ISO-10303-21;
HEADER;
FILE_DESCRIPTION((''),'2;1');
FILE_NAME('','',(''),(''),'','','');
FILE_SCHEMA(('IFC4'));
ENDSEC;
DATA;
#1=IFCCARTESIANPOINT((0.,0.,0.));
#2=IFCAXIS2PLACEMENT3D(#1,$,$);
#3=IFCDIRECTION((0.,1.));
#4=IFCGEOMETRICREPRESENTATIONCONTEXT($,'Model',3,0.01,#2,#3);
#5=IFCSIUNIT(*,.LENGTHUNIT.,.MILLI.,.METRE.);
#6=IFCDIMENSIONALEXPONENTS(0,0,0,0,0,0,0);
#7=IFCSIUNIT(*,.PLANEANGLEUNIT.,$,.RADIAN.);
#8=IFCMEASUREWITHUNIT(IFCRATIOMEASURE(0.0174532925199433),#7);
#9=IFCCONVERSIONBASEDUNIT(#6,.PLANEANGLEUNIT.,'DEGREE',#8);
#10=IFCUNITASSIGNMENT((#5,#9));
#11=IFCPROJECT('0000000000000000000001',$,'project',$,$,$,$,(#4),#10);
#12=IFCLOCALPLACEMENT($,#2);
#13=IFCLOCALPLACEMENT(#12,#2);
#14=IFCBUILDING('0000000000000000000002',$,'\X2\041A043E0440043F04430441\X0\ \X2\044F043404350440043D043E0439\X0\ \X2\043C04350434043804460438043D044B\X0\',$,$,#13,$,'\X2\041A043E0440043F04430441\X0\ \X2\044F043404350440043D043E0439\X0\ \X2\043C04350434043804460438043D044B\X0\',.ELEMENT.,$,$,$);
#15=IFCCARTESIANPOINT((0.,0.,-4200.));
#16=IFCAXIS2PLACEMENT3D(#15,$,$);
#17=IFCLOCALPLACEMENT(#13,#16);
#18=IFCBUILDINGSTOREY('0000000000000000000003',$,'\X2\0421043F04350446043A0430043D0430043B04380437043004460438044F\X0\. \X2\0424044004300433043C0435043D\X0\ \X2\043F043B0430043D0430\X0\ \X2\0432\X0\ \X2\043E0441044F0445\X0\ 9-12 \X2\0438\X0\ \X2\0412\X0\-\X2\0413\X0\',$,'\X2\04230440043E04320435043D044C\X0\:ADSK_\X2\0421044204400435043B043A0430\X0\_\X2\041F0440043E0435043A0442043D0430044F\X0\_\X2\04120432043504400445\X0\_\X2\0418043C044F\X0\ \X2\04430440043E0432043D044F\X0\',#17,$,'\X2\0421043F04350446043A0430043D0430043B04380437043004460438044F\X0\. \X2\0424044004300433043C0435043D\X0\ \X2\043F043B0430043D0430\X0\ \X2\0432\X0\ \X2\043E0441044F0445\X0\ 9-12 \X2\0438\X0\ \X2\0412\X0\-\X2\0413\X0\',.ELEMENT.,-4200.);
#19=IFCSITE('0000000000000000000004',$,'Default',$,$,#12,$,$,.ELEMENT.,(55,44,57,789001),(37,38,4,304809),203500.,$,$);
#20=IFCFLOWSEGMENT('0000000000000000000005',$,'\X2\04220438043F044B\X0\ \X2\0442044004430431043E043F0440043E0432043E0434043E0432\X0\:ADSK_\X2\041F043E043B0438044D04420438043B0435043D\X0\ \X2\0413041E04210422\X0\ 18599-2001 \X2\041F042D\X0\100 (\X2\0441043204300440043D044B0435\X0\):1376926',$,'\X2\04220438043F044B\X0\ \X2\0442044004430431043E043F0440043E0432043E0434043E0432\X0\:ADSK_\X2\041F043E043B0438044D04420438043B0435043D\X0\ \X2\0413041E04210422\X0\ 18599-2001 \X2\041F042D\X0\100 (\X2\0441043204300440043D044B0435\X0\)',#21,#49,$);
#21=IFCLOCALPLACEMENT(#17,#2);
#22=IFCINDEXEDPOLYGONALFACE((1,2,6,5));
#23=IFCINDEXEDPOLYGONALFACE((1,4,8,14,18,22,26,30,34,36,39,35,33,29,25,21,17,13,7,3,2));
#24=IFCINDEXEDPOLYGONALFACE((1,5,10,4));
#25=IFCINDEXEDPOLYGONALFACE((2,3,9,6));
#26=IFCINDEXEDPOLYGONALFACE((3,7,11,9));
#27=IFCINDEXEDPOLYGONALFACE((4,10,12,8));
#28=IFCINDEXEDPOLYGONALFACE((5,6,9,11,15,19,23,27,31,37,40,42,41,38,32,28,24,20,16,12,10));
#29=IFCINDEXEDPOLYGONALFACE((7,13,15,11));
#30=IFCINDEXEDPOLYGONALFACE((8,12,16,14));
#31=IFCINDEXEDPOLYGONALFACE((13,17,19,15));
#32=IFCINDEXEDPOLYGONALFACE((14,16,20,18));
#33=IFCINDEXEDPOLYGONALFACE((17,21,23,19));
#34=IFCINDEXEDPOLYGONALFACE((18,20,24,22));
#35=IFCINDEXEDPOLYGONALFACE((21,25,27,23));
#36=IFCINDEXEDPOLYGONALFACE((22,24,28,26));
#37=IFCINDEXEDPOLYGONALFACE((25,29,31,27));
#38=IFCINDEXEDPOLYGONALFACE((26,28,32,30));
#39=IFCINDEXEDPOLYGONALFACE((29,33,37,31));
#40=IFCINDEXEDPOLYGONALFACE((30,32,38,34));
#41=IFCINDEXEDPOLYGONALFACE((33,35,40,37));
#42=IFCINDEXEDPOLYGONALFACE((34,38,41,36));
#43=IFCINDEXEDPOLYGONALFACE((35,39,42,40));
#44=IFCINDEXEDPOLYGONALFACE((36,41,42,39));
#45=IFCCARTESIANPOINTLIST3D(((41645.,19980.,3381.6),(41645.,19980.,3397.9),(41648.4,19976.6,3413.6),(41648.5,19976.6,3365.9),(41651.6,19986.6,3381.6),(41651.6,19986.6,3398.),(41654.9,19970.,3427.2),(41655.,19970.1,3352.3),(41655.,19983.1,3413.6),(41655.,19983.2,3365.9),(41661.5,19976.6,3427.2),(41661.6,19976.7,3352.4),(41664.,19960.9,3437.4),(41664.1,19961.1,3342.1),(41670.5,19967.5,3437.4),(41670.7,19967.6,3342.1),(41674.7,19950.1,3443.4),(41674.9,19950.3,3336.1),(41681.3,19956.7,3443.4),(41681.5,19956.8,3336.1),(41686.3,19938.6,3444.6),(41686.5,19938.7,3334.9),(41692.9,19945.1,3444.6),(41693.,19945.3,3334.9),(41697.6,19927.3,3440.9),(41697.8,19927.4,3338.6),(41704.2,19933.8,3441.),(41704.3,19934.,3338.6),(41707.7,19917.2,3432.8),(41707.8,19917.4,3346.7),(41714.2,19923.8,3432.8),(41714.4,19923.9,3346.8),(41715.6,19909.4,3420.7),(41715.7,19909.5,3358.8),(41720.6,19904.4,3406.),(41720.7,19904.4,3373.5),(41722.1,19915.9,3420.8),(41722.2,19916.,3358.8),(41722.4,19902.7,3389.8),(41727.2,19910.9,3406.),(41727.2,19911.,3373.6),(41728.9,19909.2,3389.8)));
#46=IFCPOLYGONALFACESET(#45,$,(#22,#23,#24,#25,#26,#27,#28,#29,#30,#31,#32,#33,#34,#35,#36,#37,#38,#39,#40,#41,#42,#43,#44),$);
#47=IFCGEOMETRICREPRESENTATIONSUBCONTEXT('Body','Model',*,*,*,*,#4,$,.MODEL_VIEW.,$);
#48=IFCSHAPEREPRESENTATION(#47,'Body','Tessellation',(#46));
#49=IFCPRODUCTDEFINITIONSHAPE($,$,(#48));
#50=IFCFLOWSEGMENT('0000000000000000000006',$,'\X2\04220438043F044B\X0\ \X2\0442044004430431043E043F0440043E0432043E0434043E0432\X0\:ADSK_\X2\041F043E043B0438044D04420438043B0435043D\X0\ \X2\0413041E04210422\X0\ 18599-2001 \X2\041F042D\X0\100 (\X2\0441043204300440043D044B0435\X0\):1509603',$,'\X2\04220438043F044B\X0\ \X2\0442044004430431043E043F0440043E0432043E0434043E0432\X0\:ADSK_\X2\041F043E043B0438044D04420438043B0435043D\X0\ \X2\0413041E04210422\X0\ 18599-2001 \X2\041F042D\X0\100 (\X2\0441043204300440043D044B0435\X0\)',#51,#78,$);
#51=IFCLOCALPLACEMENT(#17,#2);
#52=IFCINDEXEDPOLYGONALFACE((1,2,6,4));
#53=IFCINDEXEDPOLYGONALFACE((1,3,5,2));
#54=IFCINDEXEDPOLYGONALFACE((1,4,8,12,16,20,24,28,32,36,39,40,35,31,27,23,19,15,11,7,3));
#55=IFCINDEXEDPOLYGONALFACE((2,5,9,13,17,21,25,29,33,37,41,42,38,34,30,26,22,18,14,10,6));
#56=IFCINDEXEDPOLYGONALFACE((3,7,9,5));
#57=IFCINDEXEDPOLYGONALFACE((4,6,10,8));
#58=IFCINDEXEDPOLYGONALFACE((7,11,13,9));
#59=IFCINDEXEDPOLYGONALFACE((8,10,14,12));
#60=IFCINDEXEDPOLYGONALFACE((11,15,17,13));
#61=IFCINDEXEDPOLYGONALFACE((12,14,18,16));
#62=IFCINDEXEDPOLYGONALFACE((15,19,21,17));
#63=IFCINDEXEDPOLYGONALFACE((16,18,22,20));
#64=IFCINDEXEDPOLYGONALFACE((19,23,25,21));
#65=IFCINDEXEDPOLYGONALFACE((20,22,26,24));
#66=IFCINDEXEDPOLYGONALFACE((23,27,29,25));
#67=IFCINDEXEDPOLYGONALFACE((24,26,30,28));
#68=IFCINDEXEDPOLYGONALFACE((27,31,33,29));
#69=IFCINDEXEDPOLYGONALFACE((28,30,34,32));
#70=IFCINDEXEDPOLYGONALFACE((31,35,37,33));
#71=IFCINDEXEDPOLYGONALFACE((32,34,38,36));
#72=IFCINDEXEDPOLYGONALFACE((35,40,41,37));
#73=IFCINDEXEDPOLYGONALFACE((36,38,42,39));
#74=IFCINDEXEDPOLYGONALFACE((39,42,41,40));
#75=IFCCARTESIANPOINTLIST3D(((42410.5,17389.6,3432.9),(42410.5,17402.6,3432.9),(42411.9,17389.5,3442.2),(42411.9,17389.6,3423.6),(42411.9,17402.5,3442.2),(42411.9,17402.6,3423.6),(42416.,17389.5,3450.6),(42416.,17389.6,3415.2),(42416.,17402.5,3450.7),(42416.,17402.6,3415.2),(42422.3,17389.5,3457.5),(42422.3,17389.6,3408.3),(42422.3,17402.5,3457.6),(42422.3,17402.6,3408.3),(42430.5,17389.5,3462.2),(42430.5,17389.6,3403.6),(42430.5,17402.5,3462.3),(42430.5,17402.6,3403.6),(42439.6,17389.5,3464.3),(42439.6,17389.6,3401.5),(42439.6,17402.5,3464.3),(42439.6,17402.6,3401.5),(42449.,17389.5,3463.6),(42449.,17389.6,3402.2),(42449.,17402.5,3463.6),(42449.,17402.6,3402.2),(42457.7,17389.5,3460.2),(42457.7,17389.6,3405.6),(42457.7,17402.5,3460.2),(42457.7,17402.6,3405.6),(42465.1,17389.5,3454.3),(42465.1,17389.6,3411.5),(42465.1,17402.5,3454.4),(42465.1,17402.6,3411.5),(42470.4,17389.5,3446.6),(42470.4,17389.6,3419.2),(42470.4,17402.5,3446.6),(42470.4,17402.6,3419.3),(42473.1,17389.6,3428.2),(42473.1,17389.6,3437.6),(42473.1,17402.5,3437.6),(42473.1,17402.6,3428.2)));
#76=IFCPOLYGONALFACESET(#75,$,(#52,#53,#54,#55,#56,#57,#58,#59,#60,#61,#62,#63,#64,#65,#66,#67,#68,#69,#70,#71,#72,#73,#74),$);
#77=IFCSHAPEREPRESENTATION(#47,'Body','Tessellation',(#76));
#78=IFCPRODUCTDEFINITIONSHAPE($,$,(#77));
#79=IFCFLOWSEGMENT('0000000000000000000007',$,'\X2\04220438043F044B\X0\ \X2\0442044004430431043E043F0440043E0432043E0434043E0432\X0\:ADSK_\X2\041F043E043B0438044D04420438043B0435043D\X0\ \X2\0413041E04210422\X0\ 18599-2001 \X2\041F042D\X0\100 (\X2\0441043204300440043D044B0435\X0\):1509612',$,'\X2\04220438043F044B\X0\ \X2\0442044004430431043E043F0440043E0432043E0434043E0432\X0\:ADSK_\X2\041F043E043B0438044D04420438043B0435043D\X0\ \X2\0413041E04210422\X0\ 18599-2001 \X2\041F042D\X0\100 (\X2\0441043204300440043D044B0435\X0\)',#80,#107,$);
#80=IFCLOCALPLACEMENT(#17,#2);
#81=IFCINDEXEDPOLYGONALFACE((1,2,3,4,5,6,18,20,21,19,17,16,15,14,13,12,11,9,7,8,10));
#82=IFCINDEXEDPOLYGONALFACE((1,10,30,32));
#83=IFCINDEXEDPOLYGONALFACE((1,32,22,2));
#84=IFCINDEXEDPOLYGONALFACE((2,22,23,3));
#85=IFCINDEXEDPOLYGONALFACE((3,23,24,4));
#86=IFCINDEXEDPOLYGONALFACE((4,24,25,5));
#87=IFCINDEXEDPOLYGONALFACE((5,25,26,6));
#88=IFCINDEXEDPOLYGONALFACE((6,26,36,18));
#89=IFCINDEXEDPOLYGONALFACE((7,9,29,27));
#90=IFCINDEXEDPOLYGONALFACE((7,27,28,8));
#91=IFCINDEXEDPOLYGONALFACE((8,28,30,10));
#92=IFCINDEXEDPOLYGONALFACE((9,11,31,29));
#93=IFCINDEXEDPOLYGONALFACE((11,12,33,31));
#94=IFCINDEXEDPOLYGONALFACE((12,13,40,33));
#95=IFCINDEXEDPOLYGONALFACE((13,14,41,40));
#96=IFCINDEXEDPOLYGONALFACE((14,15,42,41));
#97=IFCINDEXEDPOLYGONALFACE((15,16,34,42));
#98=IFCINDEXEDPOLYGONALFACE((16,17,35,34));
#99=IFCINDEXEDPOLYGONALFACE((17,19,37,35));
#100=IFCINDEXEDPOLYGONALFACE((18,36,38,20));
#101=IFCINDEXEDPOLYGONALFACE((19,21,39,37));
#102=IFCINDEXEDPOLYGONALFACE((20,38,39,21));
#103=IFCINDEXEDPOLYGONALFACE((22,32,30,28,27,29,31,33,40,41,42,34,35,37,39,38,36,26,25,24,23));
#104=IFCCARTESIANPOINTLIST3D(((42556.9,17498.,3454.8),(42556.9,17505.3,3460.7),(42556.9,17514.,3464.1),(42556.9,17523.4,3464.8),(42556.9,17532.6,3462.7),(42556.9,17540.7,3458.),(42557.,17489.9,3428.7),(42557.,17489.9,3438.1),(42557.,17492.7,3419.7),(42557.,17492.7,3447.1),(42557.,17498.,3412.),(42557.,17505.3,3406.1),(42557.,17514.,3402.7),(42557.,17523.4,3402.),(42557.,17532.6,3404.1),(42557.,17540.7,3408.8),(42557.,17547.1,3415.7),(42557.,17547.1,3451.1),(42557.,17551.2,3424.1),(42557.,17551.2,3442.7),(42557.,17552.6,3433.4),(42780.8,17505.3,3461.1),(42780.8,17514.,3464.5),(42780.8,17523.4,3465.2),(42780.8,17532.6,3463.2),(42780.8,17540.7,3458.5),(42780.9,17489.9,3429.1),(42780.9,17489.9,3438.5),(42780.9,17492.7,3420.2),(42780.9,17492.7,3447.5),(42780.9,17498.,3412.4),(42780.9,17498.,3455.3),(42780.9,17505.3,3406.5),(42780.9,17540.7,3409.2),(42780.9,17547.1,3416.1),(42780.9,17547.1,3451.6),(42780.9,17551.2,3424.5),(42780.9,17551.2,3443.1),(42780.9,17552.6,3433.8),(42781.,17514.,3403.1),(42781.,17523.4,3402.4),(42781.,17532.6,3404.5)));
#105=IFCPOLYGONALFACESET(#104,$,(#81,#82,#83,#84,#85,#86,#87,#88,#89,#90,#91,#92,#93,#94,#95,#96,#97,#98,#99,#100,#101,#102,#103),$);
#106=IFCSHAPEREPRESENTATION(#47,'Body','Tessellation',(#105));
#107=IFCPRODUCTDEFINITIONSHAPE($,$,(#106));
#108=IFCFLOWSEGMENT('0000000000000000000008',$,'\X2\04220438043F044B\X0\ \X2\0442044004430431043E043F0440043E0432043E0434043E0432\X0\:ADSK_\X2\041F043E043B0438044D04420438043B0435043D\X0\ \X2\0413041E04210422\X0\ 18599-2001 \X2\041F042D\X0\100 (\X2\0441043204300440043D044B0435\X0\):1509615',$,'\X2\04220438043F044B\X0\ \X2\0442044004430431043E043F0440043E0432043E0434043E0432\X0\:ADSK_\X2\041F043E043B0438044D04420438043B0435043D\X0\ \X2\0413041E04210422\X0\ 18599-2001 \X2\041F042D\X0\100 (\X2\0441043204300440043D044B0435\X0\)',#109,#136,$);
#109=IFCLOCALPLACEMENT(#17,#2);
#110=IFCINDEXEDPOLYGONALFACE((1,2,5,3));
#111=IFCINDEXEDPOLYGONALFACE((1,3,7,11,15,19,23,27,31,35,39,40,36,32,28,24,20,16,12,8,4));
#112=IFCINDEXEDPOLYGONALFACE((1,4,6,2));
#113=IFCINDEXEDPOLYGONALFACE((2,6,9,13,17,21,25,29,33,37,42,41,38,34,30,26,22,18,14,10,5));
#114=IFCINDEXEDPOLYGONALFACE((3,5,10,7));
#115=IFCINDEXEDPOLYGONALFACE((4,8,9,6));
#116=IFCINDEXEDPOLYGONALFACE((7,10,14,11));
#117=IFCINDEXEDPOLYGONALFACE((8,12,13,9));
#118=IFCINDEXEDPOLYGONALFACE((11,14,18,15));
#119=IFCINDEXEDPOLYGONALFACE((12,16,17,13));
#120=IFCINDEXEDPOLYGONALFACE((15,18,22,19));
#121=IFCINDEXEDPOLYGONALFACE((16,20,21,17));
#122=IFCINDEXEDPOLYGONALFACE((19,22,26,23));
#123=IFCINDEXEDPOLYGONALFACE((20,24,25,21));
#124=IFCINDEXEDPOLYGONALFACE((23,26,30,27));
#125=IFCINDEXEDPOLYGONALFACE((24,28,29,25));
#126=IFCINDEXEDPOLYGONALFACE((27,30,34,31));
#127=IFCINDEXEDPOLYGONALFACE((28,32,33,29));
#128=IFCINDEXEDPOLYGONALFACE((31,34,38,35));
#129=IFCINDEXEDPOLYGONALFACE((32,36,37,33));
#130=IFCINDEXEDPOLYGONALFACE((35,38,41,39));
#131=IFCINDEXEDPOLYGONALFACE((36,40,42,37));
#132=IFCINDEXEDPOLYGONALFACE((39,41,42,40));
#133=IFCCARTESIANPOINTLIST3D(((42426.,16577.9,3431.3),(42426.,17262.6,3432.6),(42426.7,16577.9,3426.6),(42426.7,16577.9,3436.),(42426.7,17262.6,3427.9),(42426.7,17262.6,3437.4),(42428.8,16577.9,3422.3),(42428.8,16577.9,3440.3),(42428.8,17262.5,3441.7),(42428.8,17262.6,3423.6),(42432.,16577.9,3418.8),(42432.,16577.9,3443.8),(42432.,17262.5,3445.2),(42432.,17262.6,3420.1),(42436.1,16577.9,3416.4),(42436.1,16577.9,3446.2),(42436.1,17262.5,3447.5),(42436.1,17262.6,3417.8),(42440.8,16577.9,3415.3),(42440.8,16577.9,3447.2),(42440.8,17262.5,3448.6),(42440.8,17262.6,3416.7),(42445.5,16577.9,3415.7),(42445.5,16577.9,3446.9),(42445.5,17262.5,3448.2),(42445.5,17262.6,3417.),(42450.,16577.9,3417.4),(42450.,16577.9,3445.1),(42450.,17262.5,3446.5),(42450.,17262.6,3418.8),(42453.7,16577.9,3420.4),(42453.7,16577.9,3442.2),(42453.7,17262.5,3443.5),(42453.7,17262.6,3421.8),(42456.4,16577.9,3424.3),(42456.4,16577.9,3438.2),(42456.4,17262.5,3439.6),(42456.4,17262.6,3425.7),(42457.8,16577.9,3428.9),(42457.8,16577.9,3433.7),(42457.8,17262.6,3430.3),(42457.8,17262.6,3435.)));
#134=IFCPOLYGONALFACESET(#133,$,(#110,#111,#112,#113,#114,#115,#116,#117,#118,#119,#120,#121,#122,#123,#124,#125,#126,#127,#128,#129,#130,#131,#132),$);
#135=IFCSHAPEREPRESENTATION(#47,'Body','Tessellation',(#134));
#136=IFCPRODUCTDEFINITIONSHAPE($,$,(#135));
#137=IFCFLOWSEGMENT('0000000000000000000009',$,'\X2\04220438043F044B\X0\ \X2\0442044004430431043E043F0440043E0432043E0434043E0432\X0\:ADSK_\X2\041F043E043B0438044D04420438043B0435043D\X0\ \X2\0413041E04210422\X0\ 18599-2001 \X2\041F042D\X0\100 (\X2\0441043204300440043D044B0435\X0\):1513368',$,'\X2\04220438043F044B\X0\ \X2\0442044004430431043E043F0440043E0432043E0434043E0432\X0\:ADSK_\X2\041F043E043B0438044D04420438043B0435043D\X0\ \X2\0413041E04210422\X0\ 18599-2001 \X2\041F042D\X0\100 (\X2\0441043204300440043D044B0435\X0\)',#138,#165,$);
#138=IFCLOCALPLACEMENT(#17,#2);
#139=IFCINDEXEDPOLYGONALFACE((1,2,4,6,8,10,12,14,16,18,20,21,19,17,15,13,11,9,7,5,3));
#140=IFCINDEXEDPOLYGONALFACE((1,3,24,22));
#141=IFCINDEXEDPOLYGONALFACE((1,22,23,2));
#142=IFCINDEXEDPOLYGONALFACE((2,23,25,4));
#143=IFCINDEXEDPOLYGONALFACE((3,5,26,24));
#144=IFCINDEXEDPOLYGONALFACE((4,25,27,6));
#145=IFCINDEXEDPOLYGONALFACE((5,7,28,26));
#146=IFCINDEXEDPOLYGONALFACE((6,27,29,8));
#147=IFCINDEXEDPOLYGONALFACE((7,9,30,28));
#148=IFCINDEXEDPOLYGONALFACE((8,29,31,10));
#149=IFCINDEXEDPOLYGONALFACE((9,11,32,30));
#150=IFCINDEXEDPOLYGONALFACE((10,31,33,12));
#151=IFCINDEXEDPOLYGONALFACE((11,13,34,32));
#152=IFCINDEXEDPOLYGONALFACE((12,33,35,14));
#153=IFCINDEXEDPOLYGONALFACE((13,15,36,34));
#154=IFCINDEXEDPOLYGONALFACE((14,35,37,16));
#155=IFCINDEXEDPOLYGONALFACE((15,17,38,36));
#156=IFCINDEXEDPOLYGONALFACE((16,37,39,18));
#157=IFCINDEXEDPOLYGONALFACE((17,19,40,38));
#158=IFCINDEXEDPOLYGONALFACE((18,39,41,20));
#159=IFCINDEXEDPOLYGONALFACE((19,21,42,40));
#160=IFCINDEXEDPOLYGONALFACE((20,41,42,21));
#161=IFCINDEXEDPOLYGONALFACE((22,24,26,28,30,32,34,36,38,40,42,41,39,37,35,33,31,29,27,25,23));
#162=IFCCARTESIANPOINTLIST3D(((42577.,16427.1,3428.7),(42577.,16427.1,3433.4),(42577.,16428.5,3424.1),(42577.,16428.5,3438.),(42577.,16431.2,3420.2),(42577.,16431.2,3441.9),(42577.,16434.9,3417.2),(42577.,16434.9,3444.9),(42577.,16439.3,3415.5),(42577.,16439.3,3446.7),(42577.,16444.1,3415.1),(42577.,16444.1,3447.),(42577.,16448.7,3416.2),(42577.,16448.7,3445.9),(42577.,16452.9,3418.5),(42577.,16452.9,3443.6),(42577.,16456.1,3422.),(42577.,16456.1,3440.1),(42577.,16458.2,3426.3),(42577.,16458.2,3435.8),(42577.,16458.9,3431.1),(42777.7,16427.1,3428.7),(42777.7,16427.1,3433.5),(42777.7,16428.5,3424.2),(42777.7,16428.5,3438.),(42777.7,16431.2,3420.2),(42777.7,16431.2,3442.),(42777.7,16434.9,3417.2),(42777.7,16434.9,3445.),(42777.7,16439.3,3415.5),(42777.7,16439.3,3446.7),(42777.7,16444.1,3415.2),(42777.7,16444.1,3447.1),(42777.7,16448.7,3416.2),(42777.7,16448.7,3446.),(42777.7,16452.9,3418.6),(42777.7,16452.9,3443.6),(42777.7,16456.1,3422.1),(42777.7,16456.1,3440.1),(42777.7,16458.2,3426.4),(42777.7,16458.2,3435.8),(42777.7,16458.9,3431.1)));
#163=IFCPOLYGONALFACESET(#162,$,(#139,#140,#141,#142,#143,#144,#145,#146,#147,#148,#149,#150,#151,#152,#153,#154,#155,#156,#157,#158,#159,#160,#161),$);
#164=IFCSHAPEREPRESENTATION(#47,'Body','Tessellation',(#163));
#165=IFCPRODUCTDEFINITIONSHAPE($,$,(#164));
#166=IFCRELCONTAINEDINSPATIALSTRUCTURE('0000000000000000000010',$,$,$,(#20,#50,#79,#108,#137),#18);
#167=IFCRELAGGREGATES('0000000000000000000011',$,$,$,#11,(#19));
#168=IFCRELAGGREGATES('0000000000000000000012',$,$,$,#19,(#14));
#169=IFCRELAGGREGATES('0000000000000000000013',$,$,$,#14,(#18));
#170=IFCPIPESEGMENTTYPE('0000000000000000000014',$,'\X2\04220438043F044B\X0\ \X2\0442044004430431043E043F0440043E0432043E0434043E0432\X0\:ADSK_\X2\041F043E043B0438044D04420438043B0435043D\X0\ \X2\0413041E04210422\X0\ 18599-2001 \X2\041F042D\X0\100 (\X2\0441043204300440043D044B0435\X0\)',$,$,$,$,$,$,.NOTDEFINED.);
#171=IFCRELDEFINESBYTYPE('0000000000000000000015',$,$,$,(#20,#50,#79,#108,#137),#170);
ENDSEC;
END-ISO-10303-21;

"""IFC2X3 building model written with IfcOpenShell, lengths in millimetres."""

from ifc_helpers import new_model, entity, si_unit, converted_unit, direction, frame, frame_2d, origin, origin_2d_with_axis, place, context, subcontext, project, spatial, circle, extrude, type_object, element, save


model = new_model("IFC2X3")

# Units and contexts
model_context = context("Model", 3, precision=0.01, world=origin(), true_north=direction((0.0, 1.0)))
body_context = subcontext(model_context, "Body", "Model", "MODEL_VIEW")
ifc_project = project(units=[si_unit("LENGTHUNIT", "METRE", prefix="MILLI"), converted_unit("PLANEANGLEUNIT", "DEGREE", entity("IfcRatioMeasure", 0.0174532925199433), si_unit("PLANEANGLEUNIT", "RADIAN"), dimensions=[0, 0, 0, 0, 0, 0, 0])], contexts=[model_context])

# Site, building, storey
site_placement = place(None, frame((0.0, 0.0, 0.0)))
site = spatial("IfcSite", under=ifc_project, at=site_placement, Name="Default", CompositionType="ELEMENT", RefLatitude=(55, 44, 57, 789001), RefLongitude=(37, 38, 4, 304809), RefElevation=203500.0)
building_placement = place(site_placement, origin())
building = spatial("IfcBuilding", under=site, at=building_placement, Name="Корпус ядерной медицины", LongName="Корпус ядерной медицины", CompositionType="ELEMENT")
storey_placement = place(building_placement, frame((0.0, 0.0, -4200.0)))
storey = spatial("IfcBuildingStorey", under=building, at=storey_placement, Name="Спецканализация. Фрагмен плана в осях 9-12 и В-Г", ObjectType="Уровень:ADSK_Стрелка_Проектная_Вверх_Имя уровня", LongName="Спецканализация. Фрагмен плана в осях 9-12 и В-Г", CompositionType="ELEMENT", Elevation=-4200.0)

# Flow segments
pipe_segment_type = type_object("IfcPipeSegmentType", Name="Типы трубопроводов:ADSK_Полиэтилен ГОСТ 18599-2001 ПЭ100 (сварные)", PredefinedType="NOTDEFINED")
flow_segment_1_placement = place(storey_placement, frame((41643.0, 19901.1, 3333.2)))
element("IfcFlowSegment", 1, at=flow_segment_1_placement, inside=storey, type_object=pipe_segment_type, Name="Типы трубопроводов:ADSK_Полиэтилен ГОСТ 18599-2001 ПЭ100 (сварные):1376926", ObjectType="Типы трубопроводов:ADSK_Полиэтилен ГОСТ 18599-2001 ПЭ100 (сварные)", context=body_context, shape_type="SweptSolid", body=[
    extrude(circle(Radius=55.0, at=frame_2d((0.0, 0.0), x_axis=(1.0, 0.0))), frame((40.5, 40.5, 56.6), z_axis=(0.707105, 0.707105, 0.002), x_axis=(0.707107, -0.707107, 0.0)), (0.0, 0.0, 1.0), 9.3),
])
flow_segment_2_placement = place(storey_placement, frame((42408.9, 17389.5, 3399.8)))
element("IfcFlowSegment", 2, at=flow_segment_2_placement, inside=storey, type_object=pipe_segment_type, Name="Типы трубопроводов:ADSK_Полиэтилен ГОСТ 18599-2001 ПЭ100 (сварные):1509603", ObjectType="Типы трубопроводов:ADSK_Полиэтилен ГОСТ 18599-2001 ПЭ100 (сварные)", context=body_context, shape_type="SweptSolid", body=[
    extrude(circle(Radius=31.5, at=origin_2d_with_axis()), frame((33.1, 0.1, 33.1), z_axis=(0.0, 0.999998, 0.002), x_axis=(-1.0, 0.0, 0.0)), (0.0, 0.0, 1.0), 13.0),
])
flow_segment_3_placement = place(storey_placement, frame((42556.9, 17488.0, 3400.3)))
element("IfcFlowSegment", 3, at=flow_segment_3_placement, inside=storey, type_object=pipe_segment_type, Name="Типы трубопроводов:ADSK_Полиэтилен ГОСТ 18599-2001 ПЭ100 (сварные):1509612", ObjectType="Типы трубопроводов:ADSK_Полиэтилен ГОСТ 18599-2001 ПЭ100 (сварные)", context=body_context, shape_type="SweptSolid", body=[
    extrude(circle(Radius=31.5, at=origin_2d_with_axis()), frame((0.1, 33.1, 33.1), z_axis=(0.999998, 0.0, 0.001933), x_axis=(0.0, 1.0, 0.0)), (0.0, 0.0, 1.0), 223.9),
])
flow_segment_4_placement = place(storey_placement, frame((42424.4, 16577.9, 3413.7)))
element("IfcFlowSegment", 4, at=flow_segment_4_placement, inside=storey, type_object=pipe_segment_type, Name="Типы трубопроводов:ADSK_Полиэтилен ГОСТ 18599-2001 ПЭ100 (сварные):1509615", ObjectType="Типы трубопроводов:ADSK_Полиэтилен ГОСТ 18599-2001 ПЭ100 (сварные)", context=body_context, shape_type="SweptSolid", body=[
    extrude(circle(Radius=16.0, at=frame_2d((0.0, 0.0), x_axis=(1.0, 0.0))), frame((17.6, 0.0, 17.6), z_axis=(0.0, 0.999998, 0.001991), x_axis=(-1.0, 0.0, 0.0)), (0.0, 0.0, 1.0), 684.7),
])
flow_segment_5_placement = place(storey_placement, frame((42577.0, 16425.3, 3413.5)))
element("IfcFlowSegment", 5, at=flow_segment_5_placement, inside=storey, type_object=pipe_segment_type, Name="Типы трубопроводов:ADSK_Полиэтилен ГОСТ 18599-2001 ПЭ100 (сварные):1513368", ObjectType="Типы трубопроводов:ADSK_Полиэтилен ГОСТ 18599-2001 ПЭ100 (сварные)", context=body_context, shape_type="SweptSolid", body=[
    extrude(circle(Radius=16.0, at=frame_2d((0.0, 0.0), x_axis=(1.0, 0.0))), frame((0.0, 17.6, 17.6), z_axis=(1.0, 0.000004, 0.000263), x_axis=(-0.000004, 1.0, 0.0)), (0.0, 0.0, 1.0), 200.7),
])

save(model, "model.ifc")
